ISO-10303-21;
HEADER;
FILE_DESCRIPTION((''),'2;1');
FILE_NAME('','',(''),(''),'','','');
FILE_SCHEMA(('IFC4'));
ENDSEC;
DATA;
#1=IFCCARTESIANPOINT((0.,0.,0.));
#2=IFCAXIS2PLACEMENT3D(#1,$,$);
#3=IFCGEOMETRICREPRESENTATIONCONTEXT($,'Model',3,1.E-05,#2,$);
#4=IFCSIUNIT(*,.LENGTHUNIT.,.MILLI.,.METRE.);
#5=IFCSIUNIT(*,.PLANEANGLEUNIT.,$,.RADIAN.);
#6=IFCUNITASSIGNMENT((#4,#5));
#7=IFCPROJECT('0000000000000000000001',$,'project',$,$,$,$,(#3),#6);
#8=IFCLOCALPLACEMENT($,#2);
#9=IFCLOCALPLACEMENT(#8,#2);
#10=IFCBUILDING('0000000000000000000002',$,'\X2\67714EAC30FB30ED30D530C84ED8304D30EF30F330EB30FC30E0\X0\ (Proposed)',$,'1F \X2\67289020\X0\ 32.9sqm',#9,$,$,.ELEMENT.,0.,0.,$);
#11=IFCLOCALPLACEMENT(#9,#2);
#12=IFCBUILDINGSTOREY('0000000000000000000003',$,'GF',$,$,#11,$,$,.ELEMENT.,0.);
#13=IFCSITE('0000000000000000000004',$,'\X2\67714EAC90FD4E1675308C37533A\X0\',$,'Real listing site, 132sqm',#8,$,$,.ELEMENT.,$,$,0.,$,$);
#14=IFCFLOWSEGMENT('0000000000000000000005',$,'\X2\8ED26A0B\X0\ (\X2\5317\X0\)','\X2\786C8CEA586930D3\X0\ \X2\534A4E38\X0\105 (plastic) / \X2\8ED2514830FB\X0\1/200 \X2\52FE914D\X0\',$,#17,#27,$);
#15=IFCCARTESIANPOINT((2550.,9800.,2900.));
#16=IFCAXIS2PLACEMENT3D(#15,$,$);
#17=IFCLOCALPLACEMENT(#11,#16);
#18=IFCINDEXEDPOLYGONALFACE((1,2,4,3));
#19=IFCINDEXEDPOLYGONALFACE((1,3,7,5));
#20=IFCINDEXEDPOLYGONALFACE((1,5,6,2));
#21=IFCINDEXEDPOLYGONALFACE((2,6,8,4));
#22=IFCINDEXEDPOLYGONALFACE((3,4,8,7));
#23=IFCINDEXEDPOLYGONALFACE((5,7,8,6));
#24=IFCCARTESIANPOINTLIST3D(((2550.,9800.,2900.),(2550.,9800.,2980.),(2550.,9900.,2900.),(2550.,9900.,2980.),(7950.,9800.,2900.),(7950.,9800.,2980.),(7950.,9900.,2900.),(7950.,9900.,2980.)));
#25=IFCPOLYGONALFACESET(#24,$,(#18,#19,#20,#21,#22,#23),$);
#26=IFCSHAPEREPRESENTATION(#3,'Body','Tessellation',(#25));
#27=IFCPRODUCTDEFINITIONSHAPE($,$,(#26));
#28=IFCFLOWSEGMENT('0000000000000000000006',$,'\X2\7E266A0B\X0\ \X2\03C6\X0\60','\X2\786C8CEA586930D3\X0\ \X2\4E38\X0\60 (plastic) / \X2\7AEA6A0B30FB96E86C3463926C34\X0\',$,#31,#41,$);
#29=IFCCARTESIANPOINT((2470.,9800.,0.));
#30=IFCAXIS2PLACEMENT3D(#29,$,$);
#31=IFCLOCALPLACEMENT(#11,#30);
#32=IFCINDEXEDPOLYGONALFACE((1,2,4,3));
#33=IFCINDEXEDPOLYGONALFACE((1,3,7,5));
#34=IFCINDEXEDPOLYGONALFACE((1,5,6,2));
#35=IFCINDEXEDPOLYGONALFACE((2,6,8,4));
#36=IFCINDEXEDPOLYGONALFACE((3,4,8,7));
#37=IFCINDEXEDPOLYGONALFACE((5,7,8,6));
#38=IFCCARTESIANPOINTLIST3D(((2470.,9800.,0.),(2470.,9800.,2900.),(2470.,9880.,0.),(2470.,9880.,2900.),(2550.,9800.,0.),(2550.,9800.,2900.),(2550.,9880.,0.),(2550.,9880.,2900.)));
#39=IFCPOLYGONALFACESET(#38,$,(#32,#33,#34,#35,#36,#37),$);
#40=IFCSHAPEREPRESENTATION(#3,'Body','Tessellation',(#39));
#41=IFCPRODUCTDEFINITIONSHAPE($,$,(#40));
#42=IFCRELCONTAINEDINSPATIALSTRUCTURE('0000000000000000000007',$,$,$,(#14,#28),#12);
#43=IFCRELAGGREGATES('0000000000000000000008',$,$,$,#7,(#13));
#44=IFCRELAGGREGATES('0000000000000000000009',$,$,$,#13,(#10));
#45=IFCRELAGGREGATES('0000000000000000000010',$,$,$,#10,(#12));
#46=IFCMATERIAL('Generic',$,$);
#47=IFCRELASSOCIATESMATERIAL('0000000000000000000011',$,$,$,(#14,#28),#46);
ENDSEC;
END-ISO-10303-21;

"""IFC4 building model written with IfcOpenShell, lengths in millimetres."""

from ifc_helpers import new_model, si_unit, frame, frame_2d, origin, place, context, project, spatial, rectangle, extrude, material, element, save


model = new_model("IFC4")

# Units and contexts
model_context = context("Model", 3, precision=1e-05, world=origin())
ifc_project = project(units=[si_unit("LENGTHUNIT", "METRE", prefix="MILLI"), si_unit("PLANEANGLEUNIT", "RADIAN")], contexts=[model_context])

# Site, building, storey
site_placement = place(None, origin())
site = spatial("IfcSite", under=ifc_project, at=site_placement, Name="東京都世田谷区", ObjectType="Real listing site, 132sqm", CompositionType="ELEMENT", RefElevation=0.0)
building_placement = place(site_placement, origin())
building = spatial("IfcBuilding", under=site, at=building_placement, Name="東京・ロフト付きワンルーム (Proposed)", ObjectType="1F 木造 32.9sqm", CompositionType="ELEMENT", ElevationOfRefHeight=0.0, ElevationOfTerrain=0.0)
storey_placement = place(building_placement, origin())
storey = spatial("IfcBuildingStorey", under=building, at=storey_placement, Name="GF", CompositionType="ELEMENT", Elevation=0.0)

# Shared definitions
ifc_material_1 = material(Name="Generic")

# Flow segments
flow_segment_1_placement = place(storey_placement, frame((2550.0, 9800.0, 2900.0)))
element("IfcFlowSegment", 1, at=flow_segment_1_placement, inside=storey, material=ifc_material_1, Name="軒樋 (北)", Description="硬質塩ビ 半丸105 (plastic) / 軒先・1/200 勾配", context=model_context, shape_type="SweptSolid", body=[
    extrude(rectangle(XDim=5400.0, YDim=100.0, at=frame_2d((2700.0, 50.0))), frame((2550.0, 9800.0, 2900.0)), (0.0, 0.0, 1.0), 80.0),
])
flow_segment_2_placement = place(storey_placement, frame((2470.0, 9800.0, 0.0)))
element("IfcFlowSegment", 2, at=flow_segment_2_placement, inside=storey, material=ifc_material_1, Name="縦樋 φ60", Description="硬質塩ビ 丸60 (plastic) / 竪樋・雨水排水", context=model_context, shape_type="SweptSolid", body=[
    extrude(rectangle(XDim=80.0, YDim=80.0, at=frame_2d((40.0, 40.0))), frame((2470.0, 9800.0, 0.0)), (0.0, 0.0, 1.0), 2900.0),
])

save(model, "model.ifc")
